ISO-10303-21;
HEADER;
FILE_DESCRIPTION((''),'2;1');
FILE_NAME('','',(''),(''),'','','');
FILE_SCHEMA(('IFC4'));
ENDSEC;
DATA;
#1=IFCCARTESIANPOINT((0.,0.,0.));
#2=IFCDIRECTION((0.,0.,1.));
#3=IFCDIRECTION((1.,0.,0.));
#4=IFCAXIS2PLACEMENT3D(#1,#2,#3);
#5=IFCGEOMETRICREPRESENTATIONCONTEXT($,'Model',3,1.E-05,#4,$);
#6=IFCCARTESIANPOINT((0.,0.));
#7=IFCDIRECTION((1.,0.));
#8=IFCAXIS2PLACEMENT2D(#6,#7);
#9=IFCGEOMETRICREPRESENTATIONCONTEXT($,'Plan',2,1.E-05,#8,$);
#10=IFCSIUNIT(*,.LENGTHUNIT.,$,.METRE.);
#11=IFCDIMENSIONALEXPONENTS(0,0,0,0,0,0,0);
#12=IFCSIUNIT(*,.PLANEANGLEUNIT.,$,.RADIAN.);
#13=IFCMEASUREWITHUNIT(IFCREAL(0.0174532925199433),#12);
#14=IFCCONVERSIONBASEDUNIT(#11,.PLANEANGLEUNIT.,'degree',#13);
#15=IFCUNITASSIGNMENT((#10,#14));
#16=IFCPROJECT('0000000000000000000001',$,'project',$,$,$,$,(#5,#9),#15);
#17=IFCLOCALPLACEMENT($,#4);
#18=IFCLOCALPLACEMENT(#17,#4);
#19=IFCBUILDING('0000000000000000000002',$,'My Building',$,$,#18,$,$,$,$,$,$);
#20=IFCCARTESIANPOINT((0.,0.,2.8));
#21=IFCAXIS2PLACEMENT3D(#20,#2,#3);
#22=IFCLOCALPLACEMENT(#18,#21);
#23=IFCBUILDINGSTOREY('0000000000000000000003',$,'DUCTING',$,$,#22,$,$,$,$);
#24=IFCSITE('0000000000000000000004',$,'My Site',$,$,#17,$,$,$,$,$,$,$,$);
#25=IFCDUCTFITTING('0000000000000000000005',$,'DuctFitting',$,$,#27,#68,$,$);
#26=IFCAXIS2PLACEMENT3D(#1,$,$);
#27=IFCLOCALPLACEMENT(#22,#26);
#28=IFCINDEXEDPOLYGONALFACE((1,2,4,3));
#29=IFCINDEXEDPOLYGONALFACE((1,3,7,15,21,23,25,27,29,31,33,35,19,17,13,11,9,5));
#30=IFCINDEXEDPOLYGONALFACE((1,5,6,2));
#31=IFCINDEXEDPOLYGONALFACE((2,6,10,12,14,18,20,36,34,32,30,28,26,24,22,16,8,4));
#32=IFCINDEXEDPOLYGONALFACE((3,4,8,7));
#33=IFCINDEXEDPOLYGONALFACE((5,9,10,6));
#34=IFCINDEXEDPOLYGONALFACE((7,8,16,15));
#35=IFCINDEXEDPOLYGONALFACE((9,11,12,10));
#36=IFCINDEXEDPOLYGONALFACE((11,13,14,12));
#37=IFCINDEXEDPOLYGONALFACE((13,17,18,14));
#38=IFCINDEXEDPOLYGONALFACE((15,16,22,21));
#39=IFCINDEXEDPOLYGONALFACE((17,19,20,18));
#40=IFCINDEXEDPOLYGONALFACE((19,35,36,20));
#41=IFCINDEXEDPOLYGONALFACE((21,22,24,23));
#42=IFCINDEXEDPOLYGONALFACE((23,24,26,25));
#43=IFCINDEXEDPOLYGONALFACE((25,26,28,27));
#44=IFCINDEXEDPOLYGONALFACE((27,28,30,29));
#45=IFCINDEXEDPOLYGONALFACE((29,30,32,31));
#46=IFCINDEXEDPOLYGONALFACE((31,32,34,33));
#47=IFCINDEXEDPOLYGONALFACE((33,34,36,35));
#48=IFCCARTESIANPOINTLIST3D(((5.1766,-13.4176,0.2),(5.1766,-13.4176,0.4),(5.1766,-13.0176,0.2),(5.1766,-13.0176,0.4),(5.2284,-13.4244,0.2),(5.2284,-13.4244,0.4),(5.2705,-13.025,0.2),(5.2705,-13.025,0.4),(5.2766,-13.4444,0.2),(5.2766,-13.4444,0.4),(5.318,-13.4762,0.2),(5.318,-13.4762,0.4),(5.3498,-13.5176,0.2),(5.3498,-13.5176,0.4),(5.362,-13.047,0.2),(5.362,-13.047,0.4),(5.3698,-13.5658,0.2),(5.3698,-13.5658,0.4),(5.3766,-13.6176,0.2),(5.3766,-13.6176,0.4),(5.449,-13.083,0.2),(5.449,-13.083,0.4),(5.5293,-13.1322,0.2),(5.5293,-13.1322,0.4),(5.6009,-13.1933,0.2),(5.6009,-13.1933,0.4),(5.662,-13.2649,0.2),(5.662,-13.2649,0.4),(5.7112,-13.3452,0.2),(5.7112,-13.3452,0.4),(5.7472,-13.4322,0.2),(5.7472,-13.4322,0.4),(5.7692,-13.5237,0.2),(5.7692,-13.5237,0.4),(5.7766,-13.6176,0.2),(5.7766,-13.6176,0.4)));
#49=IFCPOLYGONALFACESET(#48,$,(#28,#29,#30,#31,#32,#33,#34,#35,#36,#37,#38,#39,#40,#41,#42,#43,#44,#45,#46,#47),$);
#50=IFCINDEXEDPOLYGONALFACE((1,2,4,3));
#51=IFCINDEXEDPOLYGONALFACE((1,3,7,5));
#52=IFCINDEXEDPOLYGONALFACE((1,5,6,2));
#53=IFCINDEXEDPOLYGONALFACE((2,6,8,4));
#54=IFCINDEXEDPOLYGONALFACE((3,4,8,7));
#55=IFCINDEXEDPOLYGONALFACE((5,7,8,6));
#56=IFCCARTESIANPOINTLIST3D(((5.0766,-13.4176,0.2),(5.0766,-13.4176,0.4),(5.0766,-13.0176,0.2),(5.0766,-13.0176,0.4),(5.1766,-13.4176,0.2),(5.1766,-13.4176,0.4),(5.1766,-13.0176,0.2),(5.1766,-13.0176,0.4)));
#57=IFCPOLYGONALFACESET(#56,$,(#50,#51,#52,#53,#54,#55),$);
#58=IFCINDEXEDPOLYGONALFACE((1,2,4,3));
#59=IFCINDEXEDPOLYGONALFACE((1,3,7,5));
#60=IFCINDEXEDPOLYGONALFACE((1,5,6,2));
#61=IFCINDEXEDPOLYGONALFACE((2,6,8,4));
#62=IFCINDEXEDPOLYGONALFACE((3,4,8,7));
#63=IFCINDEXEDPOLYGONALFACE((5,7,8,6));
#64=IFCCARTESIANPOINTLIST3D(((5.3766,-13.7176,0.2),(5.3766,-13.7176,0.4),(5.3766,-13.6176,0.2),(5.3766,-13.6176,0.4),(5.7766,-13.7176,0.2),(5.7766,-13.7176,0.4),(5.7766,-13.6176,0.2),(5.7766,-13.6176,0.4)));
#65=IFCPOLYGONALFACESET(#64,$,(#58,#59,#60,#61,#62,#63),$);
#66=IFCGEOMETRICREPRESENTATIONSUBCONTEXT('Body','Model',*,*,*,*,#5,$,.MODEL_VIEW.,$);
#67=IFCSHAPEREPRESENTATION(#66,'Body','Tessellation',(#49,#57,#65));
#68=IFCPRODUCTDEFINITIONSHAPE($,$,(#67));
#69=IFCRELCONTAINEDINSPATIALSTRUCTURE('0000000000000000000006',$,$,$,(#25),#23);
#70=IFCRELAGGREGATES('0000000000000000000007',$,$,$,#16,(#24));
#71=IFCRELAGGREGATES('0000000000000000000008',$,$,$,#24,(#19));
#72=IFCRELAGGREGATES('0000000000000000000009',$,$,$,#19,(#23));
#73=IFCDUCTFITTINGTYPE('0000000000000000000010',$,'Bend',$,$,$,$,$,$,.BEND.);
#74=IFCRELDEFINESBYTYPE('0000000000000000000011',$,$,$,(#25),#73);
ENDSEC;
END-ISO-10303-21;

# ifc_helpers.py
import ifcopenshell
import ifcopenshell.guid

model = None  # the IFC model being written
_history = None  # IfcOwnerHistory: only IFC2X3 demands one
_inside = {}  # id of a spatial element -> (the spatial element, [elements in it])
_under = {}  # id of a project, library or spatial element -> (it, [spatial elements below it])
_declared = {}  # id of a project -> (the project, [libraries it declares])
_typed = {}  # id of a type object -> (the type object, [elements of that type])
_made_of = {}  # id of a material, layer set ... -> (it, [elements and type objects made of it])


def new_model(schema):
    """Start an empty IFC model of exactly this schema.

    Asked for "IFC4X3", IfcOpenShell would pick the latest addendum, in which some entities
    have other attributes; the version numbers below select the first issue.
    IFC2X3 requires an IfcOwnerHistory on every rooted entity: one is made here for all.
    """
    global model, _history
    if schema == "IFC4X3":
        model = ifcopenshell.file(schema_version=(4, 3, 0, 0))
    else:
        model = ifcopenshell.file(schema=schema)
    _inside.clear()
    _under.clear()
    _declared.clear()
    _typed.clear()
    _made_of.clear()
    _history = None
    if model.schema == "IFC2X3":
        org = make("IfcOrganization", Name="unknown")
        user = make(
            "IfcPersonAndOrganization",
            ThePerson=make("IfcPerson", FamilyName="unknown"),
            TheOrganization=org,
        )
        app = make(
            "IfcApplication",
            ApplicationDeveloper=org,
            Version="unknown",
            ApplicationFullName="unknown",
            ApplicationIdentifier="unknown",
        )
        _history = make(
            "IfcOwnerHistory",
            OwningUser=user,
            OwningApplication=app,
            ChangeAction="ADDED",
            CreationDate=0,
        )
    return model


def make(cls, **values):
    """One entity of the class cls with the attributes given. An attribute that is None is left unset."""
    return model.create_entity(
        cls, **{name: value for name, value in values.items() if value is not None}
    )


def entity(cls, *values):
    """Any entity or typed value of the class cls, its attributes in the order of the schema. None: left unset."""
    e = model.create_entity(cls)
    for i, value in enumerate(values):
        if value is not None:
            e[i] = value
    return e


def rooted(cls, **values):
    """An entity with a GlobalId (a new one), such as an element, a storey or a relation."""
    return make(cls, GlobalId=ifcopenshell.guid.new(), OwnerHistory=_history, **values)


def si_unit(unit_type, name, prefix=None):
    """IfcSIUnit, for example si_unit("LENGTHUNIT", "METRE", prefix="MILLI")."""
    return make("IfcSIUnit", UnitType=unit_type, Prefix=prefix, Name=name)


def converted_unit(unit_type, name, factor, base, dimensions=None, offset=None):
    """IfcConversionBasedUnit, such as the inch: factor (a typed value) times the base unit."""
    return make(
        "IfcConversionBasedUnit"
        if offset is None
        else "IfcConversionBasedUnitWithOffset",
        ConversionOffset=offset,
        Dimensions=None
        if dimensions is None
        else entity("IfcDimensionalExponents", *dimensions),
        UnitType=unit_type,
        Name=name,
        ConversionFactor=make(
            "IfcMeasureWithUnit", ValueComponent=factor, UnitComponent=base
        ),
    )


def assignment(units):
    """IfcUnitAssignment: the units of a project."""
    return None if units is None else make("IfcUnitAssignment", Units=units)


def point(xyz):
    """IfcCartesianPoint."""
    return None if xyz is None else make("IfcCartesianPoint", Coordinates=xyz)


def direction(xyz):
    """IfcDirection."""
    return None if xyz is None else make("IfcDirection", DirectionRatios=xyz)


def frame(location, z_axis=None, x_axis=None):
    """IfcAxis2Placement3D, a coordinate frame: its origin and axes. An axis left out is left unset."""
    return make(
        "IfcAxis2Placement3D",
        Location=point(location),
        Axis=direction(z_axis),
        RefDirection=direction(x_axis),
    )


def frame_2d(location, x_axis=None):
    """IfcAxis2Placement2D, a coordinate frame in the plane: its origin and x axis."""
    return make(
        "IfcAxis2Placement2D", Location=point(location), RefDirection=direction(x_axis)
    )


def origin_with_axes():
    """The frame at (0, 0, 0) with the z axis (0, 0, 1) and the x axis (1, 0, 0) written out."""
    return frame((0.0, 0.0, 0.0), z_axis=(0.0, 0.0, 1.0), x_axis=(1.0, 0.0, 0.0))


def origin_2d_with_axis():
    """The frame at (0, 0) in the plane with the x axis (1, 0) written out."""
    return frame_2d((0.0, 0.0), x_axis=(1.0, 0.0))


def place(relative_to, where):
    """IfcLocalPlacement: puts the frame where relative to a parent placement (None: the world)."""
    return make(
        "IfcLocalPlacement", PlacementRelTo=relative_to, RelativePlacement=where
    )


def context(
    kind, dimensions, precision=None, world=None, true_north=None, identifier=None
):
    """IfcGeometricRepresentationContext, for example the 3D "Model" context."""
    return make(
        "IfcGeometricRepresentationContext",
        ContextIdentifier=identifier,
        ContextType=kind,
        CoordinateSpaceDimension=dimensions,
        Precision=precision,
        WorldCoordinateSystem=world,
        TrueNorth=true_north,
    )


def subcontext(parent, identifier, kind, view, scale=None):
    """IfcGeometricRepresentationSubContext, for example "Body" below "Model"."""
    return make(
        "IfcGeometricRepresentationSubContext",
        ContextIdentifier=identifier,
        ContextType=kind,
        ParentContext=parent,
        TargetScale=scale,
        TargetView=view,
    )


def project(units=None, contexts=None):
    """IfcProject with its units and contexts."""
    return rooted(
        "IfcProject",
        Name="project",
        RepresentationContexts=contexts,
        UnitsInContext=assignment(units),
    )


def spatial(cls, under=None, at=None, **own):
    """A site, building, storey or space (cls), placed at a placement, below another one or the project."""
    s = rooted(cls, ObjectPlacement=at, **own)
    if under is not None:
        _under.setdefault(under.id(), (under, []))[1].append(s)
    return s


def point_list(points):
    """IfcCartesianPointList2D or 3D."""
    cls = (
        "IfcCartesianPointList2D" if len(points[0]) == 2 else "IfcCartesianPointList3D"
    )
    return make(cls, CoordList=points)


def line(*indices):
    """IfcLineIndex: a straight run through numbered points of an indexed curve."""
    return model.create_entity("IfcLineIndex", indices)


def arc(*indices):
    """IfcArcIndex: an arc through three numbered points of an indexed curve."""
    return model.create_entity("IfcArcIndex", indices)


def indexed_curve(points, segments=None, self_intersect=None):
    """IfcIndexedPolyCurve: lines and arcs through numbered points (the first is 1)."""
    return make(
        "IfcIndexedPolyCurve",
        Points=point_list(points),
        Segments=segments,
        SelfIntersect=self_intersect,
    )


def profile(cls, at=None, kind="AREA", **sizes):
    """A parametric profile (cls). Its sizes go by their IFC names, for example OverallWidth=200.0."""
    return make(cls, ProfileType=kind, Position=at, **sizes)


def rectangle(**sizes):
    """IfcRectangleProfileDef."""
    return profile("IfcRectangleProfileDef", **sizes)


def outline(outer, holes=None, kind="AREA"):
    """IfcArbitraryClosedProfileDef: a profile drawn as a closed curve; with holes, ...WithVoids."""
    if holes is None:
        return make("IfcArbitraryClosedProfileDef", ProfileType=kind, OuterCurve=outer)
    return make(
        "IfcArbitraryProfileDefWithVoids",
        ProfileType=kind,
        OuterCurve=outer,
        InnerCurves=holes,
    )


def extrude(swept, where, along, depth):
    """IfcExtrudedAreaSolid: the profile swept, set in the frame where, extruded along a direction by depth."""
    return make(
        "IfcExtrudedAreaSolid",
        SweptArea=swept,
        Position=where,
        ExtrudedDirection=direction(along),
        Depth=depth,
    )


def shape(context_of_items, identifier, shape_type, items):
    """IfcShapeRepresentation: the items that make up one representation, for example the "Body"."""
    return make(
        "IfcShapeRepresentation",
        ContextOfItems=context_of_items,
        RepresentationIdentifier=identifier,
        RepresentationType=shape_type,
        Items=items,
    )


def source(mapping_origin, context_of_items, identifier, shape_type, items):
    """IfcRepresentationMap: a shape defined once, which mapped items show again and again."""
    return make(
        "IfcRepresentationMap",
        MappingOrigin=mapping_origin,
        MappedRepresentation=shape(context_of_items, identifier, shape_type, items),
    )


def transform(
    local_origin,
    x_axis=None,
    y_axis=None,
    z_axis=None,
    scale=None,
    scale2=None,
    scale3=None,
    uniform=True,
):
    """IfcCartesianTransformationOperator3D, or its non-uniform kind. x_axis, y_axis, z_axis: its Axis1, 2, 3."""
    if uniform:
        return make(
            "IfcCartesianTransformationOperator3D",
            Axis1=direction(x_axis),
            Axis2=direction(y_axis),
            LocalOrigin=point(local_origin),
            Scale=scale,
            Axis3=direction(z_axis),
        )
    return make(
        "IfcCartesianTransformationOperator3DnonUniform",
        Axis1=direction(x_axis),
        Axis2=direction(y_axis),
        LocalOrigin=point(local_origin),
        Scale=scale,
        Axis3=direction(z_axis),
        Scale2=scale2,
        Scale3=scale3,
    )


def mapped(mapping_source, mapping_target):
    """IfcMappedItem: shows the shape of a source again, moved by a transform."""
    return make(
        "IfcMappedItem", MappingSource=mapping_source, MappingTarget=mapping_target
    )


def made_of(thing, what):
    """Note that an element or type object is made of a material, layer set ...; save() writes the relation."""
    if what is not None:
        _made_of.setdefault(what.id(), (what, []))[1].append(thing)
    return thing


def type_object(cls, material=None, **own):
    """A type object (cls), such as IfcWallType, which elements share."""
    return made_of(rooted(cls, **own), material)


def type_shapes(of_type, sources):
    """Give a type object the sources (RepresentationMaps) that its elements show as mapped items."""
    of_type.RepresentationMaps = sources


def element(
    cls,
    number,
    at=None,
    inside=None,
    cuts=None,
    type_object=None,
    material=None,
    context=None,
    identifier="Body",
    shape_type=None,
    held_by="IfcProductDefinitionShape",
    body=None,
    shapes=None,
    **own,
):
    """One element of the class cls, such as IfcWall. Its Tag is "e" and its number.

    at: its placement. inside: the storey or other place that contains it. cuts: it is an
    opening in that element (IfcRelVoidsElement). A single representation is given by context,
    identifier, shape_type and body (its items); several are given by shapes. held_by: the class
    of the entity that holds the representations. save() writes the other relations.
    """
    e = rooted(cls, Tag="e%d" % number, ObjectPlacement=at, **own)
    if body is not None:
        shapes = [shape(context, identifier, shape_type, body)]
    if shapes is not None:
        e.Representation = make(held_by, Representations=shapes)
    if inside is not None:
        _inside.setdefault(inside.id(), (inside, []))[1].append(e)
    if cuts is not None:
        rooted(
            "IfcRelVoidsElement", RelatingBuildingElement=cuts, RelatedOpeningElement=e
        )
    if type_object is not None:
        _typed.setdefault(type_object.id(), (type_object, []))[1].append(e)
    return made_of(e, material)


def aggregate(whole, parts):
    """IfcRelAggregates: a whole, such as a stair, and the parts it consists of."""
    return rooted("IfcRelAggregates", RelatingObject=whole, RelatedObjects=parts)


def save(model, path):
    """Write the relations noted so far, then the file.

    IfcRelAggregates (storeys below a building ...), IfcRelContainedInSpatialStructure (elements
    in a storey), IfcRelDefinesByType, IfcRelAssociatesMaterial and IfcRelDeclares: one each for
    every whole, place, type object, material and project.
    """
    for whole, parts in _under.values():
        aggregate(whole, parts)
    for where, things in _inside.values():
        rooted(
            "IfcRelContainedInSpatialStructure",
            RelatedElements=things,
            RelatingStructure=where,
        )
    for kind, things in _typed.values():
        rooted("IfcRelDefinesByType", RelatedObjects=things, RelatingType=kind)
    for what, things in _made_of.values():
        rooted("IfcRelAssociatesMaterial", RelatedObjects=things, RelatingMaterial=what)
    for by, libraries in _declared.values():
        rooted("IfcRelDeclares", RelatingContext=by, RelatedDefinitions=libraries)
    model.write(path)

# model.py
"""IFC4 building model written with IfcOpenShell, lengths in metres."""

from ifc_helpers import new_model, entity, si_unit, converted_unit, frame, origin_with_axes, origin_2d_with_axis, place, context, subcontext, project, spatial, line, arc, indexed_curve, rectangle, outline, extrude, source, transform, mapped, type_object, type_shapes, element, save


model = new_model("IFC4")

# Units and contexts
model_context = context("Model", 3, precision=1e-05, world=origin_with_axes())
plan_context = context("Plan", 2, precision=1e-05, world=origin_2d_with_axis())
body_context = subcontext(model_context, "Body", "Model", "MODEL_VIEW")
ifc_project = project(units=[si_unit("LENGTHUNIT", "METRE"), converted_unit("PLANEANGLEUNIT", "degree", entity("IfcReal", 0.0174532925199433), si_unit("PLANEANGLEUNIT", "RADIAN"), dimensions=[0, 0, 0, 0, 0, 0, 0])], contexts=[model_context, plan_context])

# Site, building, storey
site_placement = place(None, origin_with_axes())
site = spatial("IfcSite", under=ifc_project, at=site_placement, Name="My Site")
building_placement = place(site_placement, origin_with_axes())
building = spatial("IfcBuilding", under=site, at=building_placement, Name="My Building")
storey_placement = place(building_placement, frame((0.0, 0.0, 2.8), z_axis=(0.0, 0.0, 1.0), x_axis=(1.0, 0.0, 0.0)))
storey = spatial("IfcBuildingStorey", under=building, at=storey_placement, Name="DUCTING")

# Duct fitting
duct_fitting_type_1 = type_object("IfcDuctFittingType", Name="Bend", PredefinedType="BEND")
shared_shape = source(origin_with_axes(), body_context, "Body", "SweptSolid", [
    extrude(outline(indexed_curve([(0.2, 0.0), (0.2586, -0.1414), (0.4, -0.2), (0.4, -0.6), (-0.0243, -0.4243), (-0.2, 0.0)], segments=[arc(1, 2, 3), line(3, 4), arc(4, 5, 6), line(6, 1)])), frame((0.0, -0.1, -0.1), z_axis=(0.0, -1.0, 0.0), x_axis=(1.0, 0.0, 0.0)), (0.0, 0.0, -1.0), 0.2),
    extrude(rectangle(XDim=0.4, YDim=0.2), origin_with_axes(), (0.0, 0.0, -1.0), 0.1),
    extrude(rectangle(XDim=0.4, YDim=0.2), frame((0.4, 0.0, -0.5), z_axis=(1.0, 0.0, 0.0), x_axis=(0.0, 0.0, 1.0)), (0.0, 0.0, 1.0), 0.1),
])
type_shapes(duct_fitting_type_1, [shared_shape])
for number, where, z_axis, x_axis, name in (
    (1, (5.0766, -13.2176, 0.3), (-1.0, 0.0, 0.0), (0.0, -1.0, 0.0), "DuctFitting"),
):
    element("IfcDuctFitting", number, at=place(storey_placement, frame(where, z_axis=z_axis, x_axis=x_axis)), inside=storey, type_object=duct_fitting_type_1, Name=name, context=body_context, shape_type="MappedRepresentation", body=[
        mapped(shared_shape, transform((0.0, 0.0, 0.0), x_axis=(1.0, 0.0, 0.0), y_axis=(0.0, 1.0, 0.0), z_axis=(0.0, 0.0, 1.0), scale=1.0)),
    ])

save(model, "model.ifc")
